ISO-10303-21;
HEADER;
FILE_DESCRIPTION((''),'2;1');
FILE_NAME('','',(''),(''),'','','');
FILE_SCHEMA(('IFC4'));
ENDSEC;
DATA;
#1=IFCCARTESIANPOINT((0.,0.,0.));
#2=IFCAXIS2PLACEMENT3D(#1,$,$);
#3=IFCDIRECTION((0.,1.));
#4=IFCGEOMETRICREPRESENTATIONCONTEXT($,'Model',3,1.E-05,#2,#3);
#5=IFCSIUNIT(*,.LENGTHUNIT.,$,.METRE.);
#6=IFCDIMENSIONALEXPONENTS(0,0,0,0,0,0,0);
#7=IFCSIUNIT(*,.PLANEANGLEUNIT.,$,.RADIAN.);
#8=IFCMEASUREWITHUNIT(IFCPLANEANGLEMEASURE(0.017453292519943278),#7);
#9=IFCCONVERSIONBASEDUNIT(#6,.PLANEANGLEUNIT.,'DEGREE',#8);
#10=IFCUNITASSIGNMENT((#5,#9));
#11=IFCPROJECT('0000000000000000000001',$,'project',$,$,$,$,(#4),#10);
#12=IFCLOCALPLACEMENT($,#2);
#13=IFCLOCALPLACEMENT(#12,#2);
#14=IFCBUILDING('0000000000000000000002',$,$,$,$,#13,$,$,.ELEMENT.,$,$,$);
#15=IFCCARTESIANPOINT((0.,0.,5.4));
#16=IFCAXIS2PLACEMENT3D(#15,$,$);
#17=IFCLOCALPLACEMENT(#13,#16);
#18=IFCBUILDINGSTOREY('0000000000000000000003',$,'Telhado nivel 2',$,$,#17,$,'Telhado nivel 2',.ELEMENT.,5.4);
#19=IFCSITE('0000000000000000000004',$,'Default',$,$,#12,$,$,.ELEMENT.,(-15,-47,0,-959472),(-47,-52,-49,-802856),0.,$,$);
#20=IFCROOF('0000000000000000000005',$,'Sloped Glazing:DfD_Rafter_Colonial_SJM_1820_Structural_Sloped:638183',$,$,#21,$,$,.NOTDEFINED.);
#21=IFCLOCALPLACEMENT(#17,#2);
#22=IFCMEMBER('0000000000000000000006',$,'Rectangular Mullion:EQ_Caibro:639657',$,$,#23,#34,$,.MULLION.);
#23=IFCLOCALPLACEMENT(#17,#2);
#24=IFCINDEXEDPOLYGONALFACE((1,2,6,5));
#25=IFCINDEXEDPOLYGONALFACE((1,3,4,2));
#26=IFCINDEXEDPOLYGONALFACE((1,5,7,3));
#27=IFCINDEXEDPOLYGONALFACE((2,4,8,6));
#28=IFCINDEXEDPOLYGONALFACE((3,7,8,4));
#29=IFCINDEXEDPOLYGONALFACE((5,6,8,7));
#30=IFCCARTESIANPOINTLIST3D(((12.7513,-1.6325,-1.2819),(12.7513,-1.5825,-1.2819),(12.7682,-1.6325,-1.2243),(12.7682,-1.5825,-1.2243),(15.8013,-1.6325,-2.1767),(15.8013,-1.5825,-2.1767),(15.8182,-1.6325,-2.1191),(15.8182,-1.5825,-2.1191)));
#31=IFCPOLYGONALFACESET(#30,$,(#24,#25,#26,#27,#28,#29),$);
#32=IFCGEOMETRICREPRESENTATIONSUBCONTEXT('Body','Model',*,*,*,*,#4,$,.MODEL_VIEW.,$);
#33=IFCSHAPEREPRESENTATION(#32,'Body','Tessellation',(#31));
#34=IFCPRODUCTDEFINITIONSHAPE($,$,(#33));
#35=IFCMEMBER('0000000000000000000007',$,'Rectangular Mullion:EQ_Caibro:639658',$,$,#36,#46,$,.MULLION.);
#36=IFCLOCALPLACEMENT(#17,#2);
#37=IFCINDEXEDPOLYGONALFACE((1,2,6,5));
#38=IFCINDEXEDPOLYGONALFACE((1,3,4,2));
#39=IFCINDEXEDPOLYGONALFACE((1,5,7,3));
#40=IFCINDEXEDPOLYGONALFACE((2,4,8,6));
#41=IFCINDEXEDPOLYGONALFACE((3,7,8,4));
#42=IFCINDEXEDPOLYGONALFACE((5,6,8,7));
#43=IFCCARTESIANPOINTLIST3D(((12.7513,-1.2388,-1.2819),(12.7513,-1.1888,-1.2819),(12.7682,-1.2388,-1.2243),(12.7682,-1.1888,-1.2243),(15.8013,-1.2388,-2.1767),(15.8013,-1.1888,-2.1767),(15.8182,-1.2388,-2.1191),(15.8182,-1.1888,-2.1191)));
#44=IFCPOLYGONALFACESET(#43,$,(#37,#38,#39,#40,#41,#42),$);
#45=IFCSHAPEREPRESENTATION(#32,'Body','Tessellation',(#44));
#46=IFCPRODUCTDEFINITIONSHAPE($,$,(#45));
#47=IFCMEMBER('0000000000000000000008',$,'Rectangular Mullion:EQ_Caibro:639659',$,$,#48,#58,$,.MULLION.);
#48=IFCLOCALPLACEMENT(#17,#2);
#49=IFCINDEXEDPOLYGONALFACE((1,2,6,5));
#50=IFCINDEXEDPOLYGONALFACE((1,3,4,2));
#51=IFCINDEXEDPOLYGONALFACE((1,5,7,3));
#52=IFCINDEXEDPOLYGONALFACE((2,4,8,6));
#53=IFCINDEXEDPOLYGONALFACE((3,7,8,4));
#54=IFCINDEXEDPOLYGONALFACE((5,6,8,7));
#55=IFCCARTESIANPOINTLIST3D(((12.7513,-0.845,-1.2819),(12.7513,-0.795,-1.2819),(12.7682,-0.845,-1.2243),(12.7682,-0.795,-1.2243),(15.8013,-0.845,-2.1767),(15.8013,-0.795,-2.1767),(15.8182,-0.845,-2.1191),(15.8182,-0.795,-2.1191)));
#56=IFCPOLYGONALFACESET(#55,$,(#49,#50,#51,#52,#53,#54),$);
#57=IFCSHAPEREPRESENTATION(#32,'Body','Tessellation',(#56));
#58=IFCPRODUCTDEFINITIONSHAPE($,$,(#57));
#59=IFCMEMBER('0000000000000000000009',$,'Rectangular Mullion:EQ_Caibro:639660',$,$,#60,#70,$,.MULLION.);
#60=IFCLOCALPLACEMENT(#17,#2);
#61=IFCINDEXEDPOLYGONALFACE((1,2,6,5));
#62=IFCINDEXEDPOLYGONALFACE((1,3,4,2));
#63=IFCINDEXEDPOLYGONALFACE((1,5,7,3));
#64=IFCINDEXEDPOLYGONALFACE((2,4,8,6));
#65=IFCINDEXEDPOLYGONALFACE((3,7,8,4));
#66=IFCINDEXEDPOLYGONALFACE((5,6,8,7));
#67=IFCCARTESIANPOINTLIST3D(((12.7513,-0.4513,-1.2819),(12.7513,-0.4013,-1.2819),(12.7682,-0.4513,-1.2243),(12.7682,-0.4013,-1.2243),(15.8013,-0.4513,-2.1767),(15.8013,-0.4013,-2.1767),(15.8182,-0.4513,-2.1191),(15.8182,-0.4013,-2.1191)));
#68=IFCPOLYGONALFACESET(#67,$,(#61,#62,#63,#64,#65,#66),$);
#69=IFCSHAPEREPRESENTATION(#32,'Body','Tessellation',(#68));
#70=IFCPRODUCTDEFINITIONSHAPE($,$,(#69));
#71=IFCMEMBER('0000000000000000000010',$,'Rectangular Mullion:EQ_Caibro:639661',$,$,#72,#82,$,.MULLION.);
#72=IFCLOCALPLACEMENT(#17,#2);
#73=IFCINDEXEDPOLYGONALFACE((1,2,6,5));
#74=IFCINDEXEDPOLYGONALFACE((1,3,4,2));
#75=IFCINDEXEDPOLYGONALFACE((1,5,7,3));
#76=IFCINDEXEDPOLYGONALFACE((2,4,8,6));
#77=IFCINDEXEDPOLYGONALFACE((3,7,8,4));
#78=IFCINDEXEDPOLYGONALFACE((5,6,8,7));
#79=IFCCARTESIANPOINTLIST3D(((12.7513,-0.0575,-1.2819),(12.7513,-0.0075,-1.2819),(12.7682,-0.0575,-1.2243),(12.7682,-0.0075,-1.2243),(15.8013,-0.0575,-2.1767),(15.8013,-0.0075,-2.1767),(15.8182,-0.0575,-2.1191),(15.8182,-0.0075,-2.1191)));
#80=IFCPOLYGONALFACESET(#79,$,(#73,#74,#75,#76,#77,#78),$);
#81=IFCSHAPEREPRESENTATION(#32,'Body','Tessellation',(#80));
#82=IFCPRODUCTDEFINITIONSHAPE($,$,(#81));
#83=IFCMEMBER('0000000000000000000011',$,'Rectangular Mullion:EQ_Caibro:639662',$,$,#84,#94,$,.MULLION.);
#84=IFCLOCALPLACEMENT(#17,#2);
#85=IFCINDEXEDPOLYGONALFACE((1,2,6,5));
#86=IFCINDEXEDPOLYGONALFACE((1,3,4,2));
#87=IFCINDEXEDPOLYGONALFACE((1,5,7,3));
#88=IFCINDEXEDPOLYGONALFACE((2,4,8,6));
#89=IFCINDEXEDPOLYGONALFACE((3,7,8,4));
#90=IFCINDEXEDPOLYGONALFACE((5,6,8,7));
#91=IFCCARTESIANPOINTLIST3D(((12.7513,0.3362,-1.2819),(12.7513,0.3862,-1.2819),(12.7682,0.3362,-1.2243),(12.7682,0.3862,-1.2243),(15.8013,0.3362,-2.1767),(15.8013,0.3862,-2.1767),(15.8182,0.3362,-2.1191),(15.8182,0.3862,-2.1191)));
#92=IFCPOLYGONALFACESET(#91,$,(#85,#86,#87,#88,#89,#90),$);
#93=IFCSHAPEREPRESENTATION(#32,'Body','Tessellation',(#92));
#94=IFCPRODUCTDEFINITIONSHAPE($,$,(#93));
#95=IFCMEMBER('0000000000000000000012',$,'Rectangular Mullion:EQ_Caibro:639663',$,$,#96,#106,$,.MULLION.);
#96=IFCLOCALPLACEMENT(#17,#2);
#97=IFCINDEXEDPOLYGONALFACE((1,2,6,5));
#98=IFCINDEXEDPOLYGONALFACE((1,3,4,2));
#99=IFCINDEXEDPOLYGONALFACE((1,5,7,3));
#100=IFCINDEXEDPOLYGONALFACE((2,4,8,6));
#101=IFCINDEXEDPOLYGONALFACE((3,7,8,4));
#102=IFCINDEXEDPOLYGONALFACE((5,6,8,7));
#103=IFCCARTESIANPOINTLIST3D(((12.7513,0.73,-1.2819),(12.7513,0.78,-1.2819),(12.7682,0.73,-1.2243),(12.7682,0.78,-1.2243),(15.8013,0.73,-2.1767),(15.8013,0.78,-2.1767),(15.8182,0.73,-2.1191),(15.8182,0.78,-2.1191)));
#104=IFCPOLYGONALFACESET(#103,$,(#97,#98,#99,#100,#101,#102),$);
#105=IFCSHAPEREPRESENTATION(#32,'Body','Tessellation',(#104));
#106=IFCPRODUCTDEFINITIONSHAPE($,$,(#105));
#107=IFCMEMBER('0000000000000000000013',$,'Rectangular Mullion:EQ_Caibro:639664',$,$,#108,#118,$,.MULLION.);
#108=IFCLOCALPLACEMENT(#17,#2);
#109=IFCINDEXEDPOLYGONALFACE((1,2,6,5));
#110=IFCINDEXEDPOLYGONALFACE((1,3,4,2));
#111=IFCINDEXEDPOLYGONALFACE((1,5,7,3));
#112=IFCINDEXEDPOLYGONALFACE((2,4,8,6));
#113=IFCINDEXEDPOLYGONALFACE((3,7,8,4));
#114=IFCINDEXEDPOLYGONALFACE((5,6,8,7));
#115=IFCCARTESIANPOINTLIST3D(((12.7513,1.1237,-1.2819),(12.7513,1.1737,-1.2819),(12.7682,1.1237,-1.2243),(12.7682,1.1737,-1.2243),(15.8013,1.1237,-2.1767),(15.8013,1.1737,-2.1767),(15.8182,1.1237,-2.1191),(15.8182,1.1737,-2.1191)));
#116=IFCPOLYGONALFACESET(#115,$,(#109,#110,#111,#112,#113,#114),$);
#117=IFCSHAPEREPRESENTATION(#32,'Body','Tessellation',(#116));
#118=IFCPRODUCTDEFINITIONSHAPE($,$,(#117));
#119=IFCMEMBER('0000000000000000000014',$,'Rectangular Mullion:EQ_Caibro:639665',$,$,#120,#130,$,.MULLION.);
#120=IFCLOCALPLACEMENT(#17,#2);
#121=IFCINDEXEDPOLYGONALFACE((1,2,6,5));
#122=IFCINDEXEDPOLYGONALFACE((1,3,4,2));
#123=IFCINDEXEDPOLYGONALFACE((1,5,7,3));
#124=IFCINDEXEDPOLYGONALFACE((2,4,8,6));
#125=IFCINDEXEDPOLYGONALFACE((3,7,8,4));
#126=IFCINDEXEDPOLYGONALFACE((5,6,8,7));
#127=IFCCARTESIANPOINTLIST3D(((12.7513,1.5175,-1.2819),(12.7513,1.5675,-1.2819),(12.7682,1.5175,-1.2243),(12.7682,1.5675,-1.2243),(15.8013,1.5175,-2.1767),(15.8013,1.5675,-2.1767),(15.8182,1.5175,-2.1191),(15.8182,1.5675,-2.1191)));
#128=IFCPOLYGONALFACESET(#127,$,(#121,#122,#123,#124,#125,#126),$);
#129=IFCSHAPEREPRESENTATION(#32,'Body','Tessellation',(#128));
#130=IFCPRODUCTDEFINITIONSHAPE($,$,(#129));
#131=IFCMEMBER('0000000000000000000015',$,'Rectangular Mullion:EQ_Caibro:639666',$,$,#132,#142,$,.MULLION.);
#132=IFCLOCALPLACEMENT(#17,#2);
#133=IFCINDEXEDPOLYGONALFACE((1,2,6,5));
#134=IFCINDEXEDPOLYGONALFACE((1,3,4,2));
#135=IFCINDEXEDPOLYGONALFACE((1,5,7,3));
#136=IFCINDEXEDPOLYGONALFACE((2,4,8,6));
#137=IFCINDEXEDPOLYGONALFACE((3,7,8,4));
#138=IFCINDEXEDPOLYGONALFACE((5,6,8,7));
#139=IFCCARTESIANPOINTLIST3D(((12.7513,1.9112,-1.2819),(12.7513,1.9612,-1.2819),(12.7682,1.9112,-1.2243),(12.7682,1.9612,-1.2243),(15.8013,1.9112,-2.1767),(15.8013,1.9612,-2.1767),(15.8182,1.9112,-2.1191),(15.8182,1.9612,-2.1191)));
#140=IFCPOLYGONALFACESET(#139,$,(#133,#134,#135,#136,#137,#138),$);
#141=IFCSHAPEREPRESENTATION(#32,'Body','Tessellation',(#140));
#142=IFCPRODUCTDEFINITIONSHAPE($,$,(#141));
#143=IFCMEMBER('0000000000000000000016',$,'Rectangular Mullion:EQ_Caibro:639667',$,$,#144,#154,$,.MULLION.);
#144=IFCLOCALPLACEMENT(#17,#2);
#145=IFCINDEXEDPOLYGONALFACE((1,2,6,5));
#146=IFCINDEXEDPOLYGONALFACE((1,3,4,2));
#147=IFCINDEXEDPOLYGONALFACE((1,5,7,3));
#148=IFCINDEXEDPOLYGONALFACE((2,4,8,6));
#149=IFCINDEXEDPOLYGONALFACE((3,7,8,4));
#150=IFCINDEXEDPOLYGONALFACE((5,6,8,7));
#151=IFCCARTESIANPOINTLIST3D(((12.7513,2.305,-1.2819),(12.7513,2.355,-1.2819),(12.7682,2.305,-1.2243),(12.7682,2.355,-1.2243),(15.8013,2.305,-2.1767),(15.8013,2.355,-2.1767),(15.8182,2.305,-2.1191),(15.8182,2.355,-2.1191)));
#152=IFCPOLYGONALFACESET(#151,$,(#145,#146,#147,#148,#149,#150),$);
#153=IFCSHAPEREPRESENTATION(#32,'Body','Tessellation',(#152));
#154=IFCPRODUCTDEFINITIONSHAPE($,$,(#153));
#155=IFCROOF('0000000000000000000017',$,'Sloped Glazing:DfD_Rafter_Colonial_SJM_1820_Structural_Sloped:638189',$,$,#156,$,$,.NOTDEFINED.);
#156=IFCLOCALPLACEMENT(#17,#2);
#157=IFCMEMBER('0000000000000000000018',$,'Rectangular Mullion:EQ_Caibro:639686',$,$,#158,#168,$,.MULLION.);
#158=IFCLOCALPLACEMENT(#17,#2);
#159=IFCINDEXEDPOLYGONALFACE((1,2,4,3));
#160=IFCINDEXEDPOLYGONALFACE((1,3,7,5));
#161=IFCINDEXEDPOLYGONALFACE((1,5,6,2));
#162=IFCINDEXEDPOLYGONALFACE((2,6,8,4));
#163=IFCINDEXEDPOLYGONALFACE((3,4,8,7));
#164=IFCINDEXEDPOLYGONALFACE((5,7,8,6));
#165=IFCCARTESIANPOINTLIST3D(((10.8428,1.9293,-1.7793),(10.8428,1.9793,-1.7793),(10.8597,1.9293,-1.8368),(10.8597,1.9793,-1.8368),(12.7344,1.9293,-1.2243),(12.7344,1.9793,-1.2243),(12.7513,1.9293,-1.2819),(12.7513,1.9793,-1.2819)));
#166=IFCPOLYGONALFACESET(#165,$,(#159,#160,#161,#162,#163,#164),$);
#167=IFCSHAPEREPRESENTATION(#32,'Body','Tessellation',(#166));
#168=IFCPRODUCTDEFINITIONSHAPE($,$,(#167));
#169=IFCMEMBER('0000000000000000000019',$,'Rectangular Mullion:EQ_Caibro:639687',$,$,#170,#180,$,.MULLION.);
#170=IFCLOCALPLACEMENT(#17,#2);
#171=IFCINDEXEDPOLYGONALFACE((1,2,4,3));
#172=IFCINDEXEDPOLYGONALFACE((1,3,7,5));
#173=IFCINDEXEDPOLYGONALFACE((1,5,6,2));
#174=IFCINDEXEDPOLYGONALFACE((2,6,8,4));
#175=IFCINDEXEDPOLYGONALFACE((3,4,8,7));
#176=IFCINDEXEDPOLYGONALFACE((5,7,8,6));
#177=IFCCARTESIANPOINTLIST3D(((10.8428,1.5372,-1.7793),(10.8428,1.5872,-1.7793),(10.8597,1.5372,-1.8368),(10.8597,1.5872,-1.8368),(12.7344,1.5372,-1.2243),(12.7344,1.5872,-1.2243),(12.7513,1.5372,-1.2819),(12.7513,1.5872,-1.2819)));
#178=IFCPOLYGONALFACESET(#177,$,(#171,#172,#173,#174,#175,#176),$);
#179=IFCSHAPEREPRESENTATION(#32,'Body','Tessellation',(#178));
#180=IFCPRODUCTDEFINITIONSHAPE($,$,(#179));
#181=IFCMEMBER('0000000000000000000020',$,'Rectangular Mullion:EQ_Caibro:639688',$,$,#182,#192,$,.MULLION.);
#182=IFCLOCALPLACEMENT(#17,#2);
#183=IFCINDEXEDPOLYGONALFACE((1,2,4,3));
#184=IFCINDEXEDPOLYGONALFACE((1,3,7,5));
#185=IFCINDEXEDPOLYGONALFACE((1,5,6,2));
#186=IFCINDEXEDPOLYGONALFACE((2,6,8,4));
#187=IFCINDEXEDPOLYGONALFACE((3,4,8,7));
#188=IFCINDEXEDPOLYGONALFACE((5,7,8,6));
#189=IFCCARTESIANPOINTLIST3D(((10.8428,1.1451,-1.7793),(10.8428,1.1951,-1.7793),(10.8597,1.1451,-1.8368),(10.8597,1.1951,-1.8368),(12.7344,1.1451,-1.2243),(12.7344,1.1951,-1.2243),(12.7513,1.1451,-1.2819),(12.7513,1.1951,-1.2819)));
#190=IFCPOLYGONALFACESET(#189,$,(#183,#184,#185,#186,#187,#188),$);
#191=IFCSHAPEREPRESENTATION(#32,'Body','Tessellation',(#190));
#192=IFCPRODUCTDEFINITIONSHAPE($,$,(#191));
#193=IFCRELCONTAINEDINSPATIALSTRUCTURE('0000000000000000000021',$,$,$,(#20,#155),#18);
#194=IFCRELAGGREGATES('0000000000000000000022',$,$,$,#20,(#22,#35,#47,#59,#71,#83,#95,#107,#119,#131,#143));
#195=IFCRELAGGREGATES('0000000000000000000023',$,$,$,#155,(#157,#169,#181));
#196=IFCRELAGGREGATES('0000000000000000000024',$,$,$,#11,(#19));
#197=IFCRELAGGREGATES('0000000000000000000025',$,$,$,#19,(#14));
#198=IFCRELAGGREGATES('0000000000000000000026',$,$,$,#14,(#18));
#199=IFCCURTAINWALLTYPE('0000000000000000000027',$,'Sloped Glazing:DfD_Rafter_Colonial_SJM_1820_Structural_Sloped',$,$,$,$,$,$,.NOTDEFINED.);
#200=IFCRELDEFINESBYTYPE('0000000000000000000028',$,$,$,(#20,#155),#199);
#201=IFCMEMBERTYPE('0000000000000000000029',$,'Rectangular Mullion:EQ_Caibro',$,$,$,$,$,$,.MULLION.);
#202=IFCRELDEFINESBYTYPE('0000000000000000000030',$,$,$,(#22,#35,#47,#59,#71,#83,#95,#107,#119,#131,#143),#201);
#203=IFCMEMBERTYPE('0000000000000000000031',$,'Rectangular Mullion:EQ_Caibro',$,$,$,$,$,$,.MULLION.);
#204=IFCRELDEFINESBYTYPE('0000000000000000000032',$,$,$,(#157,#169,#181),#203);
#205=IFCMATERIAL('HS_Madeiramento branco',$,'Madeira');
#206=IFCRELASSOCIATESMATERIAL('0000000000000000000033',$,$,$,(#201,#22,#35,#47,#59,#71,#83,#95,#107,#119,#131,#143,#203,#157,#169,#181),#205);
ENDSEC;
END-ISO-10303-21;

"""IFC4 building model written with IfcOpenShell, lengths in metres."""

from ifc_helpers import new_model, entity, si_unit, converted_unit, direction, frame, origin, place, context, subcontext, project, spatial, indexed_curve, outline, extrude, source, transform, mapped, material, type_object, type_shapes, element, aggregate, save


model = new_model("IFC4")

# Units and contexts
model_context = context("Model", 3, precision=1e-05, world=origin(), true_north=direction((0.0, 1.0)))
body_context = subcontext(model_context, "Body", "Model", "MODEL_VIEW")
ifc_project = project(units=[si_unit("LENGTHUNIT", "METRE"), converted_unit("PLANEANGLEUNIT", "DEGREE", entity("IfcPlaneAngleMeasure", 0.017453292519943278), si_unit("PLANEANGLEUNIT", "RADIAN"), dimensions=[0, 0, 0, 0, 0, 0, 0])], contexts=[model_context])

# Site, building, storey
site_placement = place(None, origin())
site = spatial("IfcSite", under=ifc_project, at=site_placement, Name="Default", CompositionType="ELEMENT", RefLatitude=(-15, -47, 0, -959472), RefLongitude=(-47, -52, -49, -802856), RefElevation=0.0)
building_placement = place(site_placement, origin())
building = spatial("IfcBuilding", under=site, at=building_placement, CompositionType="ELEMENT")
storey_placement = place(building_placement, frame((0.0, 0.0, 5.4)))
storey = spatial("IfcBuildingStorey", under=building, at=storey_placement, Name="Telhado nivel 2", LongName="Telhado nivel 2", CompositionType="ELEMENT", Elevation=5.4)

# Roofs, members
curtain_wall_type_1 = type_object("IfcCurtainWallType", Name="Sloped Glazing:DfD_Rafter_Colonial_SJM_1820_Structural_Sloped", PredefinedType="NOTDEFINED")
roof_1_placement = place(storey_placement, frame((0.0, 0.0, -5.4)))
roof_1 = element("IfcRoof", 1, at=roof_1_placement, inside=storey, type_object=curtain_wall_type_1, Name="Sloped Glazing:DfD_Rafter_Colonial_SJM_1820_Structural_Sloped:638183", PredefinedType="NOTDEFINED")
ifc_material = material(Name="HS_Madeiramento branco", Category="Madeira")
member_type_1 = type_object("IfcMemberType", Name="Rectangular Mullion:EQ_Caibro", PredefinedType="MULLION", material=ifc_material)
shared_shape_1 = source(origin(), body_context, "Body", "SweptSolid", [
    extrude(outline(indexed_curve([(-0.025, -0.03), (0.025, -0.03), (0.025, 0.03), (-0.025, 0.03), (-0.025, -0.03)], self_intersect=False)), frame((0.0, -0.03, -3.1785), z_axis=(0.0, 0.0, 1.0), x_axis=(-1.0, 0.0, 0.0)), (0.0, 0.0, 1.0), 3.1785),
])
type_shapes(member_type_1, [shared_shape_1])
member_1_placement = place(roof_1_placement, frame((12.7513, -1.6075, 4.1181), z_axis=(-0.95956, 0.0, 0.281504), x_axis=(0.0, 1.0, 0.0)))
member_1 = element("IfcMember", 2, at=member_1_placement, type_object=member_type_1, material=ifc_material, Name="Rectangular Mullion:EQ_Caibro:639657", PredefinedType="MULLION", context=body_context, shape_type="MappedRepresentation", body=[
    mapped(shared_shape_1, transform((0.0, 0.0, 0.0), scale=1.0)),
])
member_2_placement = place(roof_1_placement, frame((12.7513, -1.2138, 4.1181), z_axis=(-0.95956, 0.0, 0.281504), x_axis=(0.0, 1.0, 0.0)))
member_2 = element("IfcMember", 3, at=member_2_placement, type_object=member_type_1, material=ifc_material, Name="Rectangular Mullion:EQ_Caibro:639658", PredefinedType="MULLION", context=body_context, shape_type="MappedRepresentation", body=[
    mapped(shared_shape_1, transform((0.0, 0.0, 0.0), scale=1.0)),
])
member_3_placement = place(roof_1_placement, frame((12.7513, -0.82, 4.1181), z_axis=(-0.95956, 0.0, 0.281504), x_axis=(0.0, 1.0, 0.0)))
member_3 = element("IfcMember", 4, at=member_3_placement, type_object=member_type_1, material=ifc_material, Name="Rectangular Mullion:EQ_Caibro:639659", PredefinedType="MULLION", context=body_context, shape_type="MappedRepresentation", body=[
    mapped(shared_shape_1, transform((0.0, 0.0, 0.0), scale=1.0)),
])
member_4_placement = place(roof_1_placement, frame((12.7513, -0.4263, 4.1181), z_axis=(-0.95956, 0.0, 0.281504), x_axis=(0.0, 1.0, 0.0)))
member_4 = element("IfcMember", 5, at=member_4_placement, type_object=member_type_1, material=ifc_material, Name="Rectangular Mullion:EQ_Caibro:639660", PredefinedType="MULLION", context=body_context, shape_type="MappedRepresentation", body=[
    mapped(shared_shape_1, transform((0.0, 0.0, 0.0), scale=1.0)),
])
member_5_placement = place(roof_1_placement, frame((12.7513, -0.0325, 4.1181), z_axis=(-0.95956, 0.0, 0.281504), x_axis=(0.0, 1.0, 0.0)))
member_5 = element("IfcMember", 6, at=member_5_placement, type_object=member_type_1, material=ifc_material, Name="Rectangular Mullion:EQ_Caibro:639661", PredefinedType="MULLION", context=body_context, shape_type="MappedRepresentation", body=[
    mapped(shared_shape_1, transform((0.0, 0.0, 0.0), scale=1.0)),
])
member_6_placement = place(roof_1_placement, frame((12.7513, 0.3612, 4.1181), z_axis=(-0.95956, 0.0, 0.281504), x_axis=(0.0, 1.0, 0.0)))
member_6 = element("IfcMember", 7, at=member_6_placement, type_object=member_type_1, material=ifc_material, Name="Rectangular Mullion:EQ_Caibro:639662", PredefinedType="MULLION", context=body_context, shape_type="MappedRepresentation", body=[
    mapped(shared_shape_1, transform((0.0, 0.0, 0.0), scale=1.0)),
])
member_7_placement = place(roof_1_placement, frame((12.7513, 0.755, 4.1181), z_axis=(-0.95956, 0.0, 0.281504), x_axis=(0.0, 1.0, 0.0)))
member_7 = element("IfcMember", 8, at=member_7_placement, type_object=member_type_1, material=ifc_material, Name="Rectangular Mullion:EQ_Caibro:639663", PredefinedType="MULLION", context=body_context, shape_type="MappedRepresentation", body=[
    mapped(shared_shape_1, transform((0.0, 0.0, 0.0), scale=1.0)),
])
member_8_placement = place(roof_1_placement, frame((12.7513, 1.1487, 4.1181), z_axis=(-0.95956, 0.0, 0.281504), x_axis=(0.0, 1.0, 0.0)))
member_8 = element("IfcMember", 9, at=member_8_placement, type_object=member_type_1, material=ifc_material, Name="Rectangular Mullion:EQ_Caibro:639664", PredefinedType="MULLION", context=body_context, shape_type="MappedRepresentation", body=[
    mapped(shared_shape_1, transform((0.0, 0.0, 0.0), scale=1.0)),
])
member_9_placement = place(roof_1_placement, frame((12.7513, 1.5425, 4.1181), z_axis=(-0.95956, 0.0, 0.281504), x_axis=(0.0, 1.0, 0.0)))
member_9 = element("IfcMember", 10, at=member_9_placement, type_object=member_type_1, material=ifc_material, Name="Rectangular Mullion:EQ_Caibro:639665", PredefinedType="MULLION", context=body_context, shape_type="MappedRepresentation", body=[
    mapped(shared_shape_1, transform((0.0, 0.0, 0.0), scale=1.0)),
])
member_10_placement = place(roof_1_placement, frame((12.7513, 1.9362, 4.1181), z_axis=(-0.95956, 0.0, 0.281504), x_axis=(0.0, 1.0, 0.0)))
member_10 = element("IfcMember", 11, at=member_10_placement, type_object=member_type_1, material=ifc_material, Name="Rectangular Mullion:EQ_Caibro:639666", PredefinedType="MULLION", context=body_context, shape_type="MappedRepresentation", body=[
    mapped(shared_shape_1, transform((0.0, 0.0, 0.0), scale=1.0)),
])
member_11_placement = place(roof_1_placement, frame((12.7513, 2.33, 4.1181), z_axis=(-0.95956, 0.0, 0.281504), x_axis=(0.0, 1.0, 0.0)))
member_11 = element("IfcMember", 12, at=member_11_placement, type_object=member_type_1, material=ifc_material, Name="Rectangular Mullion:EQ_Caibro:639667", PredefinedType="MULLION", context=body_context, shape_type="MappedRepresentation", body=[
    mapped(shared_shape_1, transform((0.0, 0.0, 0.0), scale=1.0)),
])
aggregate(roof_1, [member_1, member_2, member_3, member_4, member_5, member_6, member_7, member_8, member_9, member_10, member_11])
roof_2_placement = place(storey_placement, frame((0.0, 0.0, -5.4)))
roof_2 = element("IfcRoof", 13, at=roof_2_placement, inside=storey, type_object=curtain_wall_type_1, Name="Sloped Glazing:DfD_Rafter_Colonial_SJM_1820_Structural_Sloped:638189", PredefinedType="NOTDEFINED")
member_type_2 = type_object("IfcMemberType", Name="Rectangular Mullion:EQ_Caibro", PredefinedType="MULLION", material=ifc_material)
shared_shape_2 = source(origin(), body_context, "Body", "SweptSolid", [
    extrude(outline(indexed_curve([(-0.025, -0.03), (0.025, -0.03), (0.025, 0.03), (-0.025, 0.03), (-0.025, -0.03)], self_intersect=False)), frame((0.0, -0.03, -1.9713), z_axis=(0.0, 0.0, 1.0), x_axis=(-1.0, 0.0, 0.0)), (0.0, 0.0, 1.0), 1.9713),
])
type_shapes(member_type_2, [shared_shape_2])
member_12_placement = place(roof_2_placement, frame((12.7513, 1.9543, 4.1181), z_axis=(0.95956, 0.0, 0.281504), x_axis=(0.0, -1.0, 0.0)))
member_12 = element("IfcMember", 14, at=member_12_placement, type_object=member_type_2, material=ifc_material, Name="Rectangular Mullion:EQ_Caibro:639686", PredefinedType="MULLION", context=body_context, shape_type="MappedRepresentation", body=[
    mapped(shared_shape_2, transform((0.0, 0.0, 0.0), scale=1.0)),
])
member_13_placement = place(roof_2_placement, frame((12.7513, 1.5622, 4.1181), z_axis=(0.95956, 0.0, 0.281504), x_axis=(0.0, -1.0, 0.0)))
member_13 = element("IfcMember", 15, at=member_13_placement, type_object=member_type_2, material=ifc_material, Name="Rectangular Mullion:EQ_Caibro:639687", PredefinedType="MULLION", context=body_context, shape_type="MappedRepresentation", body=[
    mapped(shared_shape_2, transform((0.0, 0.0, 0.0), scale=1.0)),
])
member_14_placement = place(roof_2_placement, frame((12.7513, 1.1701, 4.1181), z_axis=(0.95956, 0.0, 0.281504), x_axis=(0.0, -1.0, 0.0)))
member_14 = element("IfcMember", 16, at=member_14_placement, type_object=member_type_2, material=ifc_material, Name="Rectangular Mullion:EQ_Caibro:639688", PredefinedType="MULLION", context=body_context, shape_type="MappedRepresentation", body=[
    mapped(shared_shape_2, transform((0.0, 0.0, 0.0), scale=1.0)),
])
aggregate(roof_2, [member_12, member_13, member_14])

save(model, "model.ifc")
